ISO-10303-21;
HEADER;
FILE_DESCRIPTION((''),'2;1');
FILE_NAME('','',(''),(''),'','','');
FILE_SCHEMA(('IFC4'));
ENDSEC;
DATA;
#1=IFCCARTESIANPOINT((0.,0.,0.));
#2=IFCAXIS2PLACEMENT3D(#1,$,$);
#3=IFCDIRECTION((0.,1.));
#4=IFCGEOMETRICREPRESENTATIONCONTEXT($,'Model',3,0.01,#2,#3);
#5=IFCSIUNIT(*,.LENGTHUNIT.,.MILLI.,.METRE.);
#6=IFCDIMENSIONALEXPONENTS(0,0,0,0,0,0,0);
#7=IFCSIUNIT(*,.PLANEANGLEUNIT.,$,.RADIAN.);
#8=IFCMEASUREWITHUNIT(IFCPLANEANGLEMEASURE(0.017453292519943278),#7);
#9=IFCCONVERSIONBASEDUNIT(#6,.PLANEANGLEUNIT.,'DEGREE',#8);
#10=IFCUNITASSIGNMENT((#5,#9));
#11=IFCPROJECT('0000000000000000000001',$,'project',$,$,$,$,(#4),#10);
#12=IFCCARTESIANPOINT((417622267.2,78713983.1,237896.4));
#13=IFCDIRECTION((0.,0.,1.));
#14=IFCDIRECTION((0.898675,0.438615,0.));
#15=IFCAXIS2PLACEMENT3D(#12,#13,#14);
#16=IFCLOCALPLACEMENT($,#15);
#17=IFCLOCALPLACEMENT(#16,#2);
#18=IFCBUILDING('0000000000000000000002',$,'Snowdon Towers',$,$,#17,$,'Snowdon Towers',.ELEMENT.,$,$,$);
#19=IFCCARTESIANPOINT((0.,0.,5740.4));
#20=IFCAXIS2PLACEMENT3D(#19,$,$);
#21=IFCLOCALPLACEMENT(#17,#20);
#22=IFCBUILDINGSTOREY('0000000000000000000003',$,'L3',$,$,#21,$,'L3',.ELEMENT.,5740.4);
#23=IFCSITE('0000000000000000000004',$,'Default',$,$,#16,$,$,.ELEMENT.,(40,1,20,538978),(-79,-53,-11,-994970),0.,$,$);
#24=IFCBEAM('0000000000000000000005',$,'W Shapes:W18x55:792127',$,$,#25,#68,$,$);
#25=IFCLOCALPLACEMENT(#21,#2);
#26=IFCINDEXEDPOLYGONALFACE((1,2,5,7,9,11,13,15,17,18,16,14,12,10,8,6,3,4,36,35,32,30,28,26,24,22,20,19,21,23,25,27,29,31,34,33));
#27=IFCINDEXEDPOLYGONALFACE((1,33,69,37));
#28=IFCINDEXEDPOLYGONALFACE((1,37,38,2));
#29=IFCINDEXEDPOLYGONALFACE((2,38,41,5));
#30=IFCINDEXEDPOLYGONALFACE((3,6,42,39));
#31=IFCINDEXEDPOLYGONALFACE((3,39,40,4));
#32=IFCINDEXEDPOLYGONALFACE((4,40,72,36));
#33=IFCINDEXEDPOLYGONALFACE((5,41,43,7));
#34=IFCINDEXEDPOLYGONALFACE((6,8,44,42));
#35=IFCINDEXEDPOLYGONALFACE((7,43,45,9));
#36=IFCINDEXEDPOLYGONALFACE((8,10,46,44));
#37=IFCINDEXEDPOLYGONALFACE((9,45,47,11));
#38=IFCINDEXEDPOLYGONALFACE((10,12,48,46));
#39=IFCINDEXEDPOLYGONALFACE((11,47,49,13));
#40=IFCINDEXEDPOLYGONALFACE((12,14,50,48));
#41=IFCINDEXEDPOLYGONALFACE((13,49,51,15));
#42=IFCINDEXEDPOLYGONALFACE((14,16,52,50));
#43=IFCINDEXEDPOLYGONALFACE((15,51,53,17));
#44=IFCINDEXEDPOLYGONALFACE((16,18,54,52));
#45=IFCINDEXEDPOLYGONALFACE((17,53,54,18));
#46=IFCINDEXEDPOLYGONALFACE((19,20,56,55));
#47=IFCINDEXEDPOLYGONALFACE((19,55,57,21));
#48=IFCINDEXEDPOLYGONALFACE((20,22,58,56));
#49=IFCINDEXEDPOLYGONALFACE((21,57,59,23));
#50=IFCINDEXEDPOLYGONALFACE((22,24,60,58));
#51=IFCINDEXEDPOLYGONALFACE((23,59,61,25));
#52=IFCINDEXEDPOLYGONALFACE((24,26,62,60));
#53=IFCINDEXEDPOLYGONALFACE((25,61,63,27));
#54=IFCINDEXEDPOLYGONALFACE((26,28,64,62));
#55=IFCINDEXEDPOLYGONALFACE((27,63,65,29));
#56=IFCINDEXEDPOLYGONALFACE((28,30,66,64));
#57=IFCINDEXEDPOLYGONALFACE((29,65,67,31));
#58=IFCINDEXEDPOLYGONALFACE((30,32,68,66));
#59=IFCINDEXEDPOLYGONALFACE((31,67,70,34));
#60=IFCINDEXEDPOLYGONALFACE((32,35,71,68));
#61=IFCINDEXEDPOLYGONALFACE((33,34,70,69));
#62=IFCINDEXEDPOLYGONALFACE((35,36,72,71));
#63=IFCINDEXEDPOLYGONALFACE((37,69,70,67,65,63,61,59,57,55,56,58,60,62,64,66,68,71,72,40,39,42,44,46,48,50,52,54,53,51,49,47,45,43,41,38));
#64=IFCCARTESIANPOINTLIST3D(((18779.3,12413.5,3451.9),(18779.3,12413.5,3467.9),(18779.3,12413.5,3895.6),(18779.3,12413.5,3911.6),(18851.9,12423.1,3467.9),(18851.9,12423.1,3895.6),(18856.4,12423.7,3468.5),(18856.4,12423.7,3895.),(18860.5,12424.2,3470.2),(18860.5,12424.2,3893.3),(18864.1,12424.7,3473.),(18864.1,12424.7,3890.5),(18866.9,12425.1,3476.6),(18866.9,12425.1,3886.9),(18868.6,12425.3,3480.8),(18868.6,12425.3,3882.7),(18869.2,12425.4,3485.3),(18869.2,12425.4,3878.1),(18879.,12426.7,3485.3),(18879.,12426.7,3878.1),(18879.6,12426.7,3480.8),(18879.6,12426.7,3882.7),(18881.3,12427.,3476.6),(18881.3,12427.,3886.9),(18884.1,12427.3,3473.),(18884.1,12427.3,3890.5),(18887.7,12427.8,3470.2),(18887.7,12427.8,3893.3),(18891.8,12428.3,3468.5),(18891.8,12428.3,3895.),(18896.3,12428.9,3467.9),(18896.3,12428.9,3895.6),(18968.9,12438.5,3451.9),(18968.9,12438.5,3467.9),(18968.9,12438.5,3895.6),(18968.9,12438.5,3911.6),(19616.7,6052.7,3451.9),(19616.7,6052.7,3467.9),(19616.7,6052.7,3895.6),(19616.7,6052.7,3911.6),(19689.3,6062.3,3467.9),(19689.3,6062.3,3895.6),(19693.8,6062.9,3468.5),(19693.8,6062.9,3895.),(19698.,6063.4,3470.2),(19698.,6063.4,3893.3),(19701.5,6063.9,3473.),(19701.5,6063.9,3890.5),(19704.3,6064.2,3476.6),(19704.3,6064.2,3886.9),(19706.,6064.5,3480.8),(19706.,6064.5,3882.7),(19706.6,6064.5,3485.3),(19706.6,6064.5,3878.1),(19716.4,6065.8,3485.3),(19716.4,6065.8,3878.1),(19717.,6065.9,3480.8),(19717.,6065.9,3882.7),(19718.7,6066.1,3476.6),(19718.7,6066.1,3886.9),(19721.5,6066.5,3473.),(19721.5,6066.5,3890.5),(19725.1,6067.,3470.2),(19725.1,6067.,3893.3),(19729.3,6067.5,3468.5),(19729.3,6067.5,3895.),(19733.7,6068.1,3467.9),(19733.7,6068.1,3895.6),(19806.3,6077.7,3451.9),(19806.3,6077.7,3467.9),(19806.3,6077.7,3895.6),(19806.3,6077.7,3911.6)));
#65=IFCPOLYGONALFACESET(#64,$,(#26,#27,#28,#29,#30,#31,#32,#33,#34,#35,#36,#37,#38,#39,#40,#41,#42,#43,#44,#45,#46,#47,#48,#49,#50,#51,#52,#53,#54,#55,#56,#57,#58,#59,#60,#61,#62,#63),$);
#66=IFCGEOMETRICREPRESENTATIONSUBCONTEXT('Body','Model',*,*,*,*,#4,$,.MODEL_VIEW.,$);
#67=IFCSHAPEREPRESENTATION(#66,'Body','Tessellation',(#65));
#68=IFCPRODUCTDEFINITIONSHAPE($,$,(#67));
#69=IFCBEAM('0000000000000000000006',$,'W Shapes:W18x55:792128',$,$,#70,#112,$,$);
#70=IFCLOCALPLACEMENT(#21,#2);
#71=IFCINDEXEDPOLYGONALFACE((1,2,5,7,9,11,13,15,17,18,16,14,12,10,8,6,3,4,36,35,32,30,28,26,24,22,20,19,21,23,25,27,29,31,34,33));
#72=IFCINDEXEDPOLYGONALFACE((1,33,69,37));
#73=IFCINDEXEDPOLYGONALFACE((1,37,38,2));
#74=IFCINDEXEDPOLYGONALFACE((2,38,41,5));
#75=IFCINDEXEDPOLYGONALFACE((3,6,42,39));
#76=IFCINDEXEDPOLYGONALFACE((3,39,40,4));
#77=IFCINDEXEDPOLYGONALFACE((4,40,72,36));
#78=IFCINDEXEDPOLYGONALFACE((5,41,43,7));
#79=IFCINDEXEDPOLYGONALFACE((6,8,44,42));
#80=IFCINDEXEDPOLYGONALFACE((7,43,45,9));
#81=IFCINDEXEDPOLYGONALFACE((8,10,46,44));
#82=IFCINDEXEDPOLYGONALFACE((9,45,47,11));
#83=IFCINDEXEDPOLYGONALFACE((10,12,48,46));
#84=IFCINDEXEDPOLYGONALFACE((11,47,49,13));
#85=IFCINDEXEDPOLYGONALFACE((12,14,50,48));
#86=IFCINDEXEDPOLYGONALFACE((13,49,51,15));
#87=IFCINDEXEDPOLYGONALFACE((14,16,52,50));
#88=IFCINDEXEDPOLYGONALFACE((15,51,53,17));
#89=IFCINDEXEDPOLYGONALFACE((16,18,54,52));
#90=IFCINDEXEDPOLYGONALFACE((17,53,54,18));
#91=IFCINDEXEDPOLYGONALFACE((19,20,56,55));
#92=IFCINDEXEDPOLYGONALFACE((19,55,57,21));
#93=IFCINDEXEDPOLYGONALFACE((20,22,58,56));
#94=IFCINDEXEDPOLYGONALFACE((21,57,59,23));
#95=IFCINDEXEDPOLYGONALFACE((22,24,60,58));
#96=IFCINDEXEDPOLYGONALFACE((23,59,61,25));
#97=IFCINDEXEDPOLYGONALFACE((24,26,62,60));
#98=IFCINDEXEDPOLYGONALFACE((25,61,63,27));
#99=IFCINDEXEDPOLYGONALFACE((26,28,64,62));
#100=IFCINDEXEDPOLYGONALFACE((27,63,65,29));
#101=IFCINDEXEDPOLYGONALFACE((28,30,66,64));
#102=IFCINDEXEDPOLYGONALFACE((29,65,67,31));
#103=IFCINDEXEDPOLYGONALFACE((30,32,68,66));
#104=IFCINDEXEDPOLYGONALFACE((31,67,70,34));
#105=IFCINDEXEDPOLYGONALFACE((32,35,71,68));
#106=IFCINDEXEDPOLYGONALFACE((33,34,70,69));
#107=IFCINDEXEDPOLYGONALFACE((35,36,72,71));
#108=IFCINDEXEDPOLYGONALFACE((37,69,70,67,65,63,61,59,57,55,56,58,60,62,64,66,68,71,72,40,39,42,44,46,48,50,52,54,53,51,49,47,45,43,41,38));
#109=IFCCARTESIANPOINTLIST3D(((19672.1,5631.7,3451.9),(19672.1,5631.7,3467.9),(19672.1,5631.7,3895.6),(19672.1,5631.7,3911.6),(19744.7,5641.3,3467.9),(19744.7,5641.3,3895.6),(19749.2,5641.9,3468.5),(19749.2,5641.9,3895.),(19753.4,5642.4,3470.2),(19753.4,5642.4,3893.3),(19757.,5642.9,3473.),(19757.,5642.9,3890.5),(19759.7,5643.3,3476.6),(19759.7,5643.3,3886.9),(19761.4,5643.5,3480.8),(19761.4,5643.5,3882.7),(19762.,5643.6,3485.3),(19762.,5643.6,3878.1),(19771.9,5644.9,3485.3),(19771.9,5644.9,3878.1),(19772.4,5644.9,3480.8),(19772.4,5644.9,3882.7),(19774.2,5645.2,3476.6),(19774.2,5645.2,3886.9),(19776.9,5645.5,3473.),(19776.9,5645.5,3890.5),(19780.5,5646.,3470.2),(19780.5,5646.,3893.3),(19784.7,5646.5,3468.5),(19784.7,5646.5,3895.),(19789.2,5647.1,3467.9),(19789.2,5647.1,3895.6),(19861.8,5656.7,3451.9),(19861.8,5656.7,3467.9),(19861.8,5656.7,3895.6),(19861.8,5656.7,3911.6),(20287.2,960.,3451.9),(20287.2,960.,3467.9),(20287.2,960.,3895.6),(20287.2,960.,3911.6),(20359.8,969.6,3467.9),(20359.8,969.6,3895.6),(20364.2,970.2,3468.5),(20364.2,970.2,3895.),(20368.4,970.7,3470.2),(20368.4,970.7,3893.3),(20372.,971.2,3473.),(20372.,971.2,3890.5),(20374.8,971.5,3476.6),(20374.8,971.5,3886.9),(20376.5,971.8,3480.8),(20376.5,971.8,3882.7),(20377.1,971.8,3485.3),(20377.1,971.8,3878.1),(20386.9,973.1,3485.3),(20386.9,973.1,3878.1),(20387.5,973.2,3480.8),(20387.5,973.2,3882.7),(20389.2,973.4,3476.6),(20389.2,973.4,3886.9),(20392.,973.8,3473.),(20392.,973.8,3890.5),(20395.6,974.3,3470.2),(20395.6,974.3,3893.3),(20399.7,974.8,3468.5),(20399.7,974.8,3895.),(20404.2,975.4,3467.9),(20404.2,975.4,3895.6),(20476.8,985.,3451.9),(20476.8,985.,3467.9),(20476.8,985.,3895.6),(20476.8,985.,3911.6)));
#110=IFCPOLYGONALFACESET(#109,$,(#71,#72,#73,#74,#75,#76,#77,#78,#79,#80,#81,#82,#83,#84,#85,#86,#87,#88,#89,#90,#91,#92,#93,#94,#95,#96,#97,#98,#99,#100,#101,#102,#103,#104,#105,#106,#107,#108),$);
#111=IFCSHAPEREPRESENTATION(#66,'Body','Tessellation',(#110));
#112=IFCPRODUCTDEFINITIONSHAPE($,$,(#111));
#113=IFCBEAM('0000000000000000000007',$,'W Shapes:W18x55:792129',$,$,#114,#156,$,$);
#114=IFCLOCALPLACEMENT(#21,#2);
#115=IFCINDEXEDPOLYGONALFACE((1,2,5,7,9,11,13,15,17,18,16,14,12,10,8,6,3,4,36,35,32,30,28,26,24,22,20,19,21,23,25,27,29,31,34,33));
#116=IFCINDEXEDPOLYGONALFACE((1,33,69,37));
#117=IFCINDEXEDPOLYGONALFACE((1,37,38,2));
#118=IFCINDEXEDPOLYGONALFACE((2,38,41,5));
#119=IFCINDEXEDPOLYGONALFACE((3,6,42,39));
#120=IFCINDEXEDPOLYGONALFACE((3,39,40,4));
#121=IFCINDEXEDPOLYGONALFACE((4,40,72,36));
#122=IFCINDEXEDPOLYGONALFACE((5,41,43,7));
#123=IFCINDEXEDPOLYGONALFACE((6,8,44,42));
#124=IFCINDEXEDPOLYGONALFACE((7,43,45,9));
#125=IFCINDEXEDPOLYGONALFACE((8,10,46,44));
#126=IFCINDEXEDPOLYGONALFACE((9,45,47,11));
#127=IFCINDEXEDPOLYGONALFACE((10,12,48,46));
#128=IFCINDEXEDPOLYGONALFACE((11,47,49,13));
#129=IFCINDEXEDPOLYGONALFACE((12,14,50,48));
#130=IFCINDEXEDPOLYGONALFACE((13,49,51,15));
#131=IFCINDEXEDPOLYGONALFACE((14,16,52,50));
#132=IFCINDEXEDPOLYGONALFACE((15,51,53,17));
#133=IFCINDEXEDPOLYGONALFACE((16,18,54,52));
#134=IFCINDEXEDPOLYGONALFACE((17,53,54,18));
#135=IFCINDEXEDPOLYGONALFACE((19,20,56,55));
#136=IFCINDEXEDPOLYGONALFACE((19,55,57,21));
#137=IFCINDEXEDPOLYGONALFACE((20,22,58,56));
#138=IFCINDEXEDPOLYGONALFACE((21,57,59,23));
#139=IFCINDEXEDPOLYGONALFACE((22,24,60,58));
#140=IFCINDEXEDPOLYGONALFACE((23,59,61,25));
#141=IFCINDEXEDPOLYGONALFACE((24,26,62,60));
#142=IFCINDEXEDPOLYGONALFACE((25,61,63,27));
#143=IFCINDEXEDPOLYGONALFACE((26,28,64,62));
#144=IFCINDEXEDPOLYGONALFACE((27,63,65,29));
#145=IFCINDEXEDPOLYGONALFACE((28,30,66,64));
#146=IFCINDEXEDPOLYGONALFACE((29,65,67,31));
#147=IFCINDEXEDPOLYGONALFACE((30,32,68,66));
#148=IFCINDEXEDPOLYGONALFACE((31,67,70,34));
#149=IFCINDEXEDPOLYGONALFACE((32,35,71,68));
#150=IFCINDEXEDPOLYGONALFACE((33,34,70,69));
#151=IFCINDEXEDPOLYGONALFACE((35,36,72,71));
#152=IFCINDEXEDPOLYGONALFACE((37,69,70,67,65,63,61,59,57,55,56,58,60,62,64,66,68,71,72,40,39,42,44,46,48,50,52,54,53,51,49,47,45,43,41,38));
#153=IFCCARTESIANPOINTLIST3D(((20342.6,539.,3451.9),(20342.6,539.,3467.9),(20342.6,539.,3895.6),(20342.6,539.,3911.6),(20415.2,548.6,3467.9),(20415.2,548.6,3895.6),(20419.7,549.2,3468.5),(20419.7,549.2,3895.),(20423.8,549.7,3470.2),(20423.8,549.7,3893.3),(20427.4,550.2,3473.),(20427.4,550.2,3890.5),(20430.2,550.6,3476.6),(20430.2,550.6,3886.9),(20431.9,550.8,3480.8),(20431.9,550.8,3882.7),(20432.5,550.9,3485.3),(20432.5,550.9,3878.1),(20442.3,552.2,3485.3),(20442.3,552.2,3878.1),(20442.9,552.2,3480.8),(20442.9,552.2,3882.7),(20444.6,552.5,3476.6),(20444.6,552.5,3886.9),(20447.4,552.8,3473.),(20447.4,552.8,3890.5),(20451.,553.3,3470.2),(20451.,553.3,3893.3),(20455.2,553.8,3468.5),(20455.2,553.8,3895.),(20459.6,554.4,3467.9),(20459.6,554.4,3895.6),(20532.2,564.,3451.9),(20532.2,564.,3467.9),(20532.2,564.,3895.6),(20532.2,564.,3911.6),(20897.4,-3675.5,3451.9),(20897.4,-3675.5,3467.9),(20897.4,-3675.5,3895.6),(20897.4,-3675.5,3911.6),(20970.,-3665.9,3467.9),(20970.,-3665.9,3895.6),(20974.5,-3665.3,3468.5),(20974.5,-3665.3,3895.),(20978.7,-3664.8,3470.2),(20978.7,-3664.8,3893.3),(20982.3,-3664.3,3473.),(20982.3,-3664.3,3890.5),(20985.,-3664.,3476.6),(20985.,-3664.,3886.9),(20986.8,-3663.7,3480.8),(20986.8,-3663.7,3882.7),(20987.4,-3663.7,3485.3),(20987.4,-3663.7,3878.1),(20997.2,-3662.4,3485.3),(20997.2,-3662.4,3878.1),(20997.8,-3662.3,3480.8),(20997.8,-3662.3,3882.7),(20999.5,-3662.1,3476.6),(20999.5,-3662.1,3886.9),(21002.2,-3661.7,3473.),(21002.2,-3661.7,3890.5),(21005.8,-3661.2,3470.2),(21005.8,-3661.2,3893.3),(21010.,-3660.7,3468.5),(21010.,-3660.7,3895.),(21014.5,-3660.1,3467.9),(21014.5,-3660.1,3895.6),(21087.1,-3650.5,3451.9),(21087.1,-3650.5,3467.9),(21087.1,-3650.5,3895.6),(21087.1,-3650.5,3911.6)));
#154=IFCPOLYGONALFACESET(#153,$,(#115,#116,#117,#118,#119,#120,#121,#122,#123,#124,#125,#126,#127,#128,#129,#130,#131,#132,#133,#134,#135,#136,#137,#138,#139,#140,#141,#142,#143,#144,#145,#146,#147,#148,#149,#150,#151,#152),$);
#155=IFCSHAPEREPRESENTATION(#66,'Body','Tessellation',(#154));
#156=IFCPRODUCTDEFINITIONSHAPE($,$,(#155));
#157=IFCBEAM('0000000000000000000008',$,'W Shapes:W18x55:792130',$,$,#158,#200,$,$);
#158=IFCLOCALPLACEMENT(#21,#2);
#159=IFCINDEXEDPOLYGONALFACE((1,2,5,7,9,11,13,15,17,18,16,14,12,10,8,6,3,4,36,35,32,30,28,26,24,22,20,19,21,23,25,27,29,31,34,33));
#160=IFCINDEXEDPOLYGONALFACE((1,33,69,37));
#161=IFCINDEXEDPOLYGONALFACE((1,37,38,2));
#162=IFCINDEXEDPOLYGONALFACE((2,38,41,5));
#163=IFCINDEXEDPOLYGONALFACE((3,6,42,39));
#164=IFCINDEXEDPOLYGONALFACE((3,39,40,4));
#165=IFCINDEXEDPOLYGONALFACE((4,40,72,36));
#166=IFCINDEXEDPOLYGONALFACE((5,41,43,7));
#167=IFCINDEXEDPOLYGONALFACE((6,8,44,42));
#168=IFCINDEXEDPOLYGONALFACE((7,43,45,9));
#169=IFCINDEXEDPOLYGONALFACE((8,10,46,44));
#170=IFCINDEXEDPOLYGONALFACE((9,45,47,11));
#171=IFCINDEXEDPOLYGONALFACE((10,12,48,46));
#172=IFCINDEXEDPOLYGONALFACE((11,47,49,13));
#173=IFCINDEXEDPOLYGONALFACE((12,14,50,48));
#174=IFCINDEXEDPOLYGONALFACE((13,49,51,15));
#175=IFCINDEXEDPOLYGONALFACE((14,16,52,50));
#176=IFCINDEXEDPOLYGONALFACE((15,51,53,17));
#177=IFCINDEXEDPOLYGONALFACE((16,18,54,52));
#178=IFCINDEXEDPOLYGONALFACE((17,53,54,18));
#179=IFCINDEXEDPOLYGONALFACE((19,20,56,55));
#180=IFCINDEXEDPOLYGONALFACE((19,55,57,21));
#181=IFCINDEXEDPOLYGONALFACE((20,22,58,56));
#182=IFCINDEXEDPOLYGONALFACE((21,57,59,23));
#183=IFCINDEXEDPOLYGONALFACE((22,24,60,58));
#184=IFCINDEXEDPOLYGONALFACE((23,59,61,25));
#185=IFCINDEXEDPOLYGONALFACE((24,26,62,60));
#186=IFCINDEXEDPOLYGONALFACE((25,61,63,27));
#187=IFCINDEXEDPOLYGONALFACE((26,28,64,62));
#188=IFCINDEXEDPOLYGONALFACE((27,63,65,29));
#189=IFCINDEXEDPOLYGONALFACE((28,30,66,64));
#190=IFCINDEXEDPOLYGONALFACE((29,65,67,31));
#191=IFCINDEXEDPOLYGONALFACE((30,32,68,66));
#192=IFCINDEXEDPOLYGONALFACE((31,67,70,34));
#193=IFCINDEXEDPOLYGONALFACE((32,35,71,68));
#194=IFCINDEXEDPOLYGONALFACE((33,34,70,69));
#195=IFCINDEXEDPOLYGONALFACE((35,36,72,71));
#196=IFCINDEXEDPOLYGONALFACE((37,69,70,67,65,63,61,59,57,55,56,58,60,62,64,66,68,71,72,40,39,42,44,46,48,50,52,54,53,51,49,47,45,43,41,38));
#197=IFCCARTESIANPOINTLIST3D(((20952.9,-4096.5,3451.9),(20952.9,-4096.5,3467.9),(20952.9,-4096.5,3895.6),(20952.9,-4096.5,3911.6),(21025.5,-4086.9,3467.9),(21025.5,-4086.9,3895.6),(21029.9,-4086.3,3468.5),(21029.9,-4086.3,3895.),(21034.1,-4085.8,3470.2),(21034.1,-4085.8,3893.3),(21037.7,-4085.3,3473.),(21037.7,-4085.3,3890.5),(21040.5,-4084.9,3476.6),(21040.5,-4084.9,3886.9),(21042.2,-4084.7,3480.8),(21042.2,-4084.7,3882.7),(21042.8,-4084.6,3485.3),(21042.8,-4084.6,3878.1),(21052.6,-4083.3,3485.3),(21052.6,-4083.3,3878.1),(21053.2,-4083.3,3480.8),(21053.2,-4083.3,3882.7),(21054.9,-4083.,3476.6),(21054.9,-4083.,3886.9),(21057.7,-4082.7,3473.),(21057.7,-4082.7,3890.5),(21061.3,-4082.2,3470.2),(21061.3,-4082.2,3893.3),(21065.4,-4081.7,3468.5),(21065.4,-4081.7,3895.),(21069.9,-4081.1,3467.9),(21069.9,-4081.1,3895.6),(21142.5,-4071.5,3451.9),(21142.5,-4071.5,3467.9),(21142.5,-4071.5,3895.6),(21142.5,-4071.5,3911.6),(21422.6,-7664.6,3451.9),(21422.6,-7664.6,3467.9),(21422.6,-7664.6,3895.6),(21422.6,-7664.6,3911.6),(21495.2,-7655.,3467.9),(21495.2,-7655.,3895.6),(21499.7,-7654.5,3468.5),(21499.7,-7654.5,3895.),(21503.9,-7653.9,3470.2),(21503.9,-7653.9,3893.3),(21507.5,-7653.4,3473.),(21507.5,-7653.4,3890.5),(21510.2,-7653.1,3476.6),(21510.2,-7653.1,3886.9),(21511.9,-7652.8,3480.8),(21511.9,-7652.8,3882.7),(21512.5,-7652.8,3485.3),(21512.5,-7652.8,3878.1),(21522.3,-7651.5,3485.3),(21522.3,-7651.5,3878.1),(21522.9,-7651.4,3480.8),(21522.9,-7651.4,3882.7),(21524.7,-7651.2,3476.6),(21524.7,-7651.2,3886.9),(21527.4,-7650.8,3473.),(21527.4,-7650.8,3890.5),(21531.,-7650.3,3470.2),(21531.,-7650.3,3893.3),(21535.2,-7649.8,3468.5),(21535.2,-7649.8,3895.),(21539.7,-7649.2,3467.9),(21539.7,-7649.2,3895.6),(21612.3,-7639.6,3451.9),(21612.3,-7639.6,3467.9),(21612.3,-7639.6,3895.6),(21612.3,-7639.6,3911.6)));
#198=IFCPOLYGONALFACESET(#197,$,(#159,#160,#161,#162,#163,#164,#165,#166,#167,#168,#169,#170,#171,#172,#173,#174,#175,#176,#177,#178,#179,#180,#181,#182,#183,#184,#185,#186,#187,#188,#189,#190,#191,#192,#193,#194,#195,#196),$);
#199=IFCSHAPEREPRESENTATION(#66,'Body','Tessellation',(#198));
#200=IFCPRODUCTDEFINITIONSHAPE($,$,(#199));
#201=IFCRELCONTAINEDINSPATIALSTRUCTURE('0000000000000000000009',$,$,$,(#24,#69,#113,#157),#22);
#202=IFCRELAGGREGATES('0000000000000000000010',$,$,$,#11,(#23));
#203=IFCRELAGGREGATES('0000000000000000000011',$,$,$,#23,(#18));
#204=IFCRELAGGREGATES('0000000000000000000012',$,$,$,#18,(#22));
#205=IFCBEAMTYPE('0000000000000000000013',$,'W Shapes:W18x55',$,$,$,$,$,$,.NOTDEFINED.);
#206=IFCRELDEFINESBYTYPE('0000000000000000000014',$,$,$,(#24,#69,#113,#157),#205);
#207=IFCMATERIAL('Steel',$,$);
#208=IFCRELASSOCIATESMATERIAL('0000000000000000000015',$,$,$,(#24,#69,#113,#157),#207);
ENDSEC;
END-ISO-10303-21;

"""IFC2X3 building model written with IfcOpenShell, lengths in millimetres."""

from ifc_helpers import new_model, entity, si_unit, converted_unit, direction, frame, frame_2d, origin, place, context, subcontext, project, spatial, i_section, extrude, material, type_object, element, save


model = new_model("IFC2X3")

# Units and contexts
model_context = context("Model", 3, precision=0.01, world=origin(), true_north=direction((0.0, 1.0)))
body_context = subcontext(model_context, "Body", "Model", "MODEL_VIEW")
ifc_project = project(units=[si_unit("LENGTHUNIT", "METRE", prefix="MILLI"), converted_unit("PLANEANGLEUNIT", "DEGREE", entity("IfcPlaneAngleMeasure", 0.017453292519943278), si_unit("PLANEANGLEUNIT", "RADIAN"), dimensions=[0, 0, 0, 0, 0, 0, 0])], contexts=[model_context])

# Site, building, storey
site_placement = place(None, frame((417622267.2, 78713983.1, 237896.4), z_axis=(0.0, 0.0, 1.0), x_axis=(0.898675, 0.438615, 0.0)))
site = spatial("IfcSite", under=ifc_project, at=site_placement, Name="Default", CompositionType="ELEMENT", RefLatitude=(40, 1, 20, 538978), RefLongitude=(-79, -53, -11, -994970), RefElevation=0.0)
building_placement = place(site_placement, origin())
building = spatial("IfcBuilding", under=site, at=building_placement, Name="Snowdon Towers", LongName="Snowdon Towers", CompositionType="ELEMENT")
storey_placement = place(building_placement, frame((0.0, 0.0, 5740.4)))
storey = spatial("IfcBuildingStorey", under=building, at=storey_placement, Name="L3", LongName="L3", CompositionType="ELEMENT", Elevation=5740.4)

# Shared definitions
ifc_material_1 = material(Name="Steel")

# Beams
beam_type_1 = type_object("IfcBeamType", Name="W Shapes:W18x55", PredefinedType="NOTDEFINED")
beam_1_placement = place(storey_placement, frame((18846.4, 12636.5, 3911.6), z_axis=(0.0, 0.0, 1.0), x_axis=(0.130526, -0.991445, 0.0)))
element("IfcBeam", 1, at=beam_1_placement, inside=storey, type_object=beam_type_1, material=ifc_material_1, Name="W Shapes:W18x55:792127", context=body_context, shape_type="SweptSolid", body=[
    extrude(i_section(OverallWidth=191.3, OverallDepth=459.7, WebThickness=9.9, FlangeThickness=16.0, FilletRadius=17.5, at=frame_2d((0.0, 0.0), x_axis=(0.0, 1.0))), frame((212.3, 0.0, -229.9), z_axis=(1.0, 0.0, 0.0), x_axis=(0.0, 0.0, -1.0)), (0.0, 0.0, 1.0), 6415.7),
])
beam_2_placement = place(storey_placement, frame((19739.2, 5854.7, 3911.6), z_axis=(0.0, 0.0, 1.0), x_axis=(0.130526, -0.991445, 0.0)))
element("IfcBeam", 2, at=beam_2_placement, inside=storey, type_object=beam_type_1, material=ifc_material_1, Name="W Shapes:W18x55:792128", context=body_context, shape_type="SweptSolid", body=[
    extrude(i_section(OverallWidth=191.3, OverallDepth=459.7, WebThickness=9.9, FlangeThickness=16.0, FilletRadius=17.5, at=frame_2d((0.0, 0.0), x_axis=(0.0, 1.0))), frame((212.3, 0.0, -229.9), z_axis=(1.0, 0.0, 0.0), x_axis=(0.0, 0.0, -1.0)), (0.0, 0.0, 1.0), 4712.0),
])
beam_3_placement = place(storey_placement, frame((20409.7, 762.0, 3911.6), z_axis=(0.0, 0.0, 1.0), x_axis=(0.130526, -0.991445, 0.0)))
element("IfcBeam", 3, at=beam_3_placement, inside=storey, type_object=beam_type_1, material=ifc_material_1, Name="W Shapes:W18x55:792129", context=body_context, shape_type="SweptSolid", body=[
    extrude(i_section(OverallWidth=191.3, OverallDepth=459.7, WebThickness=9.9, FlangeThickness=16.0, FilletRadius=17.5, at=frame_2d((0.0, 0.0), x_axis=(0.0, 1.0))), frame((212.3, 0.0, -229.9), z_axis=(1.0, 0.0, 0.0), x_axis=(0.0, 0.0, -1.0)), (0.0, 0.0, 1.0), 4250.9),
])
beam_4_placement = place(storey_placement, frame((21020.0, -3873.5, 3911.6), z_axis=(0.0, 0.0, 1.0), x_axis=(0.130526, -0.991445, 0.0)))
element("IfcBeam", 4, at=beam_4_placement, inside=storey, type_object=beam_type_1, material=ifc_material_1, Name="W Shapes:W18x55:792130", context=body_context, shape_type="SweptSolid", body=[
    extrude(i_section(OverallWidth=191.3, OverallDepth=459.7, WebThickness=9.9, FlangeThickness=16.0, FilletRadius=17.5, at=frame_2d((0.0, 0.0), x_axis=(0.0, 1.0))), frame((212.3, 0.0, -229.9), z_axis=(1.0, 0.0, 0.0), x_axis=(0.0, 0.0, -1.0)), (0.0, 0.0, 1.0), 3598.9),
])

save(model, "model.ifc")
